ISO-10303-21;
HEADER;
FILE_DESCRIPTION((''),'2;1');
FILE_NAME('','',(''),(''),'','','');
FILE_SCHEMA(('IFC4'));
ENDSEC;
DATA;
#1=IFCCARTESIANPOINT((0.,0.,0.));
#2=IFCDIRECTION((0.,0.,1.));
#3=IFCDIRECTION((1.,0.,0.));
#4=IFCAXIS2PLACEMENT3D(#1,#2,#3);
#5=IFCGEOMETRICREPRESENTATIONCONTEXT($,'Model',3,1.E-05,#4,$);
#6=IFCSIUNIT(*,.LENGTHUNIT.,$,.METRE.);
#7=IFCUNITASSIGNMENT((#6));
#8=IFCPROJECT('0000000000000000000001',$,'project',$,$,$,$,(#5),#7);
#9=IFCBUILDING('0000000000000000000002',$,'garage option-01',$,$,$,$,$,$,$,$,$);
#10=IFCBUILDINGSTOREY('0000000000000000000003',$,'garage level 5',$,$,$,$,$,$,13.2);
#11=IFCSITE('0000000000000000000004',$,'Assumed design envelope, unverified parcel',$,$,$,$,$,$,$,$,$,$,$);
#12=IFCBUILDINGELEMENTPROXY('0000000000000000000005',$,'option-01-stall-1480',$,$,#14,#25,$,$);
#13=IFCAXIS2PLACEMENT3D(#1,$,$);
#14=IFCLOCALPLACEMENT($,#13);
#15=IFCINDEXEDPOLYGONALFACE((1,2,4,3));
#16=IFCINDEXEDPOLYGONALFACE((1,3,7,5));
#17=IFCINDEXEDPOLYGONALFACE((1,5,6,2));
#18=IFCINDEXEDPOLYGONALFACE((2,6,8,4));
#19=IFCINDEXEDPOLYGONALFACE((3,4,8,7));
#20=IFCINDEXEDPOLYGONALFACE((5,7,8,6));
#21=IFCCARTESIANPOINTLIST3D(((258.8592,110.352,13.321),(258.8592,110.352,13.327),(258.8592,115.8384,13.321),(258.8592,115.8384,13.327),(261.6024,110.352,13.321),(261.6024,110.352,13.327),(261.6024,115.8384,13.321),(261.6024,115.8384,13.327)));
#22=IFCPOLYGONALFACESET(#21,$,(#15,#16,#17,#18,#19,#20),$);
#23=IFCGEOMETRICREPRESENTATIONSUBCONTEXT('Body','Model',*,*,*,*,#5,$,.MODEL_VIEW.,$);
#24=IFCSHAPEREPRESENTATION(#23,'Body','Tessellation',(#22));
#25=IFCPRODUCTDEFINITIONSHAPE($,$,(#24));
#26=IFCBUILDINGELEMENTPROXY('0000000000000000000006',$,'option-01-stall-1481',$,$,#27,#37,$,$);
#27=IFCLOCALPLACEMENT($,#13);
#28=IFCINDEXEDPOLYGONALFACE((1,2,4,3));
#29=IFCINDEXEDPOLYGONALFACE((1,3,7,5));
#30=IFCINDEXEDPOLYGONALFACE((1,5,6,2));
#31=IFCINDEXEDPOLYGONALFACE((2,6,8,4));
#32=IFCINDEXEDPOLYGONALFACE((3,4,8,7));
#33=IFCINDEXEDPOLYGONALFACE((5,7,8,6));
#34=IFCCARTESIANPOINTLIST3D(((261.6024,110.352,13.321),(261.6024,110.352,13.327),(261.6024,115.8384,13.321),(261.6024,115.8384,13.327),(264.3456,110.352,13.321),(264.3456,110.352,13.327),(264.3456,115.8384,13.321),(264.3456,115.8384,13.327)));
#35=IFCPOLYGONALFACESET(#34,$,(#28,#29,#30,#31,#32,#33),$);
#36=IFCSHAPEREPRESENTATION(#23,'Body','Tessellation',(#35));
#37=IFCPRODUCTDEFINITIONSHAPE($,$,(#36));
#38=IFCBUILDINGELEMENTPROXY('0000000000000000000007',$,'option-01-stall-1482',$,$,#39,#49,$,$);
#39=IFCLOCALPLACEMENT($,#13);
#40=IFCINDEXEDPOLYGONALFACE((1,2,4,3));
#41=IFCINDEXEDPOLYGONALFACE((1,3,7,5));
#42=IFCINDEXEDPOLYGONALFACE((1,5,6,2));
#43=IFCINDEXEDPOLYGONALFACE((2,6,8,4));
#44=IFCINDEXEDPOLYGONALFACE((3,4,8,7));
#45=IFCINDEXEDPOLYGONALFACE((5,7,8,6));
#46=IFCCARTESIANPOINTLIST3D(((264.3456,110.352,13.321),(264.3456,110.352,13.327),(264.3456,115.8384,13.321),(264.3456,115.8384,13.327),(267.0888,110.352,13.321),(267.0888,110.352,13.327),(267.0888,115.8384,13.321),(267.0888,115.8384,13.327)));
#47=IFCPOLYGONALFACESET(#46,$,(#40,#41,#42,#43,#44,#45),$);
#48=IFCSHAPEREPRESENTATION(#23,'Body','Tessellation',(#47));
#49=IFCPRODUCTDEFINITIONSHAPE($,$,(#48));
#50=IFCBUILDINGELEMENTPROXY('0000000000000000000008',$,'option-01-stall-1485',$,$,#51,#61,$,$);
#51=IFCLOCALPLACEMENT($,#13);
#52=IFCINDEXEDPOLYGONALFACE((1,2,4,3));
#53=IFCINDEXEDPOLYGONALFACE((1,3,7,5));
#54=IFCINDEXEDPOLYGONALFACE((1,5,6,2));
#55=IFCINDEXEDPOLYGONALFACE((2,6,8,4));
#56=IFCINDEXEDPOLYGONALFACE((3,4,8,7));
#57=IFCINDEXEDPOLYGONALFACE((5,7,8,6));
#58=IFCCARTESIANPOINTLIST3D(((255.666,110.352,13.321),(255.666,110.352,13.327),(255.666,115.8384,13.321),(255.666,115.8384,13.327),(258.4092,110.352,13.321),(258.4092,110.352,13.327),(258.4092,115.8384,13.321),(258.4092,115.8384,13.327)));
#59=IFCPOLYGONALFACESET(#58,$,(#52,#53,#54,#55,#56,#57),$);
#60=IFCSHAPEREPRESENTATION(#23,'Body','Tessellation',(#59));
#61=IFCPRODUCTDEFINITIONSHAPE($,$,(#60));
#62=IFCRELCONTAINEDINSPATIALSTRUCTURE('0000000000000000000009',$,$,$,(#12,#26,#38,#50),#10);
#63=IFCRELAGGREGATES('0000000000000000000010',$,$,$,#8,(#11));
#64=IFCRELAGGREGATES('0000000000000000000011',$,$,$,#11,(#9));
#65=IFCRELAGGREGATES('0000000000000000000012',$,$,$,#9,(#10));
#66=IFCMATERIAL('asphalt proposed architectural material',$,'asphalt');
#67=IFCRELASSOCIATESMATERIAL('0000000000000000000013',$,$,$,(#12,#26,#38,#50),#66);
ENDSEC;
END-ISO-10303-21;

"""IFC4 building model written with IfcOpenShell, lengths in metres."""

from ifc_helpers import new_model, si_unit, frame, origin_with_axes, place, context, subcontext, project, spatial, rectangle, extrude, material, element, save


model = new_model("IFC4")

# Units and contexts
model_context = context("Model", 3, precision=1e-05, world=origin_with_axes())
body_context = subcontext(model_context, "Body", "Model", "MODEL_VIEW")
ifc_project = project(units=[si_unit("LENGTHUNIT", "METRE")], contexts=[model_context])

# Site, building, storey
site = spatial("IfcSite", under=ifc_project, Name="Assumed design envelope, unverified parcel")
building = spatial("IfcBuilding", under=site, Name="garage option-01")
storey = spatial("IfcBuildingStorey", under=building, Name="garage level 5", Elevation=13.2)

# Building element proxies
ifc_material_1 = material(Name="asphalt proposed architectural material", Category="asphalt")
for number, where, z_axis, x_axis, name in (
    (1, (260.2308, 113.0952, 13.321), (0.0, 0.0, 1.0), (1.0, 0.0, 0.0), "option-01-stall-1480"),
    (2, (262.974, 113.0952, 13.321), (0.0, 0.0, 1.0), (1.0, 0.0, 0.0), "option-01-stall-1481"),
    (3, (265.7172, 113.0952, 13.321), (0.0, 0.0, 1.0), (1.0, 0.0, 0.0), "option-01-stall-1482"),
    (4, (257.0376, 113.0952, 13.321), (0.0, 0.0, 1.0), (1.0, 0.0, 0.0), "option-01-stall-1485"),
):
    element("IfcBuildingElementProxy", number, at=place(None, frame(where, z_axis=z_axis, x_axis=x_axis)), inside=storey, material=ifc_material_1, Name=name, context=body_context, shape_type="SweptSolid", body=[
        extrude(rectangle(XDim=2.7432, YDim=5.4864), origin_with_axes(), (0.0, 0.0, 1.0), 0.006),
    ])

save(model, "model.ifc")
